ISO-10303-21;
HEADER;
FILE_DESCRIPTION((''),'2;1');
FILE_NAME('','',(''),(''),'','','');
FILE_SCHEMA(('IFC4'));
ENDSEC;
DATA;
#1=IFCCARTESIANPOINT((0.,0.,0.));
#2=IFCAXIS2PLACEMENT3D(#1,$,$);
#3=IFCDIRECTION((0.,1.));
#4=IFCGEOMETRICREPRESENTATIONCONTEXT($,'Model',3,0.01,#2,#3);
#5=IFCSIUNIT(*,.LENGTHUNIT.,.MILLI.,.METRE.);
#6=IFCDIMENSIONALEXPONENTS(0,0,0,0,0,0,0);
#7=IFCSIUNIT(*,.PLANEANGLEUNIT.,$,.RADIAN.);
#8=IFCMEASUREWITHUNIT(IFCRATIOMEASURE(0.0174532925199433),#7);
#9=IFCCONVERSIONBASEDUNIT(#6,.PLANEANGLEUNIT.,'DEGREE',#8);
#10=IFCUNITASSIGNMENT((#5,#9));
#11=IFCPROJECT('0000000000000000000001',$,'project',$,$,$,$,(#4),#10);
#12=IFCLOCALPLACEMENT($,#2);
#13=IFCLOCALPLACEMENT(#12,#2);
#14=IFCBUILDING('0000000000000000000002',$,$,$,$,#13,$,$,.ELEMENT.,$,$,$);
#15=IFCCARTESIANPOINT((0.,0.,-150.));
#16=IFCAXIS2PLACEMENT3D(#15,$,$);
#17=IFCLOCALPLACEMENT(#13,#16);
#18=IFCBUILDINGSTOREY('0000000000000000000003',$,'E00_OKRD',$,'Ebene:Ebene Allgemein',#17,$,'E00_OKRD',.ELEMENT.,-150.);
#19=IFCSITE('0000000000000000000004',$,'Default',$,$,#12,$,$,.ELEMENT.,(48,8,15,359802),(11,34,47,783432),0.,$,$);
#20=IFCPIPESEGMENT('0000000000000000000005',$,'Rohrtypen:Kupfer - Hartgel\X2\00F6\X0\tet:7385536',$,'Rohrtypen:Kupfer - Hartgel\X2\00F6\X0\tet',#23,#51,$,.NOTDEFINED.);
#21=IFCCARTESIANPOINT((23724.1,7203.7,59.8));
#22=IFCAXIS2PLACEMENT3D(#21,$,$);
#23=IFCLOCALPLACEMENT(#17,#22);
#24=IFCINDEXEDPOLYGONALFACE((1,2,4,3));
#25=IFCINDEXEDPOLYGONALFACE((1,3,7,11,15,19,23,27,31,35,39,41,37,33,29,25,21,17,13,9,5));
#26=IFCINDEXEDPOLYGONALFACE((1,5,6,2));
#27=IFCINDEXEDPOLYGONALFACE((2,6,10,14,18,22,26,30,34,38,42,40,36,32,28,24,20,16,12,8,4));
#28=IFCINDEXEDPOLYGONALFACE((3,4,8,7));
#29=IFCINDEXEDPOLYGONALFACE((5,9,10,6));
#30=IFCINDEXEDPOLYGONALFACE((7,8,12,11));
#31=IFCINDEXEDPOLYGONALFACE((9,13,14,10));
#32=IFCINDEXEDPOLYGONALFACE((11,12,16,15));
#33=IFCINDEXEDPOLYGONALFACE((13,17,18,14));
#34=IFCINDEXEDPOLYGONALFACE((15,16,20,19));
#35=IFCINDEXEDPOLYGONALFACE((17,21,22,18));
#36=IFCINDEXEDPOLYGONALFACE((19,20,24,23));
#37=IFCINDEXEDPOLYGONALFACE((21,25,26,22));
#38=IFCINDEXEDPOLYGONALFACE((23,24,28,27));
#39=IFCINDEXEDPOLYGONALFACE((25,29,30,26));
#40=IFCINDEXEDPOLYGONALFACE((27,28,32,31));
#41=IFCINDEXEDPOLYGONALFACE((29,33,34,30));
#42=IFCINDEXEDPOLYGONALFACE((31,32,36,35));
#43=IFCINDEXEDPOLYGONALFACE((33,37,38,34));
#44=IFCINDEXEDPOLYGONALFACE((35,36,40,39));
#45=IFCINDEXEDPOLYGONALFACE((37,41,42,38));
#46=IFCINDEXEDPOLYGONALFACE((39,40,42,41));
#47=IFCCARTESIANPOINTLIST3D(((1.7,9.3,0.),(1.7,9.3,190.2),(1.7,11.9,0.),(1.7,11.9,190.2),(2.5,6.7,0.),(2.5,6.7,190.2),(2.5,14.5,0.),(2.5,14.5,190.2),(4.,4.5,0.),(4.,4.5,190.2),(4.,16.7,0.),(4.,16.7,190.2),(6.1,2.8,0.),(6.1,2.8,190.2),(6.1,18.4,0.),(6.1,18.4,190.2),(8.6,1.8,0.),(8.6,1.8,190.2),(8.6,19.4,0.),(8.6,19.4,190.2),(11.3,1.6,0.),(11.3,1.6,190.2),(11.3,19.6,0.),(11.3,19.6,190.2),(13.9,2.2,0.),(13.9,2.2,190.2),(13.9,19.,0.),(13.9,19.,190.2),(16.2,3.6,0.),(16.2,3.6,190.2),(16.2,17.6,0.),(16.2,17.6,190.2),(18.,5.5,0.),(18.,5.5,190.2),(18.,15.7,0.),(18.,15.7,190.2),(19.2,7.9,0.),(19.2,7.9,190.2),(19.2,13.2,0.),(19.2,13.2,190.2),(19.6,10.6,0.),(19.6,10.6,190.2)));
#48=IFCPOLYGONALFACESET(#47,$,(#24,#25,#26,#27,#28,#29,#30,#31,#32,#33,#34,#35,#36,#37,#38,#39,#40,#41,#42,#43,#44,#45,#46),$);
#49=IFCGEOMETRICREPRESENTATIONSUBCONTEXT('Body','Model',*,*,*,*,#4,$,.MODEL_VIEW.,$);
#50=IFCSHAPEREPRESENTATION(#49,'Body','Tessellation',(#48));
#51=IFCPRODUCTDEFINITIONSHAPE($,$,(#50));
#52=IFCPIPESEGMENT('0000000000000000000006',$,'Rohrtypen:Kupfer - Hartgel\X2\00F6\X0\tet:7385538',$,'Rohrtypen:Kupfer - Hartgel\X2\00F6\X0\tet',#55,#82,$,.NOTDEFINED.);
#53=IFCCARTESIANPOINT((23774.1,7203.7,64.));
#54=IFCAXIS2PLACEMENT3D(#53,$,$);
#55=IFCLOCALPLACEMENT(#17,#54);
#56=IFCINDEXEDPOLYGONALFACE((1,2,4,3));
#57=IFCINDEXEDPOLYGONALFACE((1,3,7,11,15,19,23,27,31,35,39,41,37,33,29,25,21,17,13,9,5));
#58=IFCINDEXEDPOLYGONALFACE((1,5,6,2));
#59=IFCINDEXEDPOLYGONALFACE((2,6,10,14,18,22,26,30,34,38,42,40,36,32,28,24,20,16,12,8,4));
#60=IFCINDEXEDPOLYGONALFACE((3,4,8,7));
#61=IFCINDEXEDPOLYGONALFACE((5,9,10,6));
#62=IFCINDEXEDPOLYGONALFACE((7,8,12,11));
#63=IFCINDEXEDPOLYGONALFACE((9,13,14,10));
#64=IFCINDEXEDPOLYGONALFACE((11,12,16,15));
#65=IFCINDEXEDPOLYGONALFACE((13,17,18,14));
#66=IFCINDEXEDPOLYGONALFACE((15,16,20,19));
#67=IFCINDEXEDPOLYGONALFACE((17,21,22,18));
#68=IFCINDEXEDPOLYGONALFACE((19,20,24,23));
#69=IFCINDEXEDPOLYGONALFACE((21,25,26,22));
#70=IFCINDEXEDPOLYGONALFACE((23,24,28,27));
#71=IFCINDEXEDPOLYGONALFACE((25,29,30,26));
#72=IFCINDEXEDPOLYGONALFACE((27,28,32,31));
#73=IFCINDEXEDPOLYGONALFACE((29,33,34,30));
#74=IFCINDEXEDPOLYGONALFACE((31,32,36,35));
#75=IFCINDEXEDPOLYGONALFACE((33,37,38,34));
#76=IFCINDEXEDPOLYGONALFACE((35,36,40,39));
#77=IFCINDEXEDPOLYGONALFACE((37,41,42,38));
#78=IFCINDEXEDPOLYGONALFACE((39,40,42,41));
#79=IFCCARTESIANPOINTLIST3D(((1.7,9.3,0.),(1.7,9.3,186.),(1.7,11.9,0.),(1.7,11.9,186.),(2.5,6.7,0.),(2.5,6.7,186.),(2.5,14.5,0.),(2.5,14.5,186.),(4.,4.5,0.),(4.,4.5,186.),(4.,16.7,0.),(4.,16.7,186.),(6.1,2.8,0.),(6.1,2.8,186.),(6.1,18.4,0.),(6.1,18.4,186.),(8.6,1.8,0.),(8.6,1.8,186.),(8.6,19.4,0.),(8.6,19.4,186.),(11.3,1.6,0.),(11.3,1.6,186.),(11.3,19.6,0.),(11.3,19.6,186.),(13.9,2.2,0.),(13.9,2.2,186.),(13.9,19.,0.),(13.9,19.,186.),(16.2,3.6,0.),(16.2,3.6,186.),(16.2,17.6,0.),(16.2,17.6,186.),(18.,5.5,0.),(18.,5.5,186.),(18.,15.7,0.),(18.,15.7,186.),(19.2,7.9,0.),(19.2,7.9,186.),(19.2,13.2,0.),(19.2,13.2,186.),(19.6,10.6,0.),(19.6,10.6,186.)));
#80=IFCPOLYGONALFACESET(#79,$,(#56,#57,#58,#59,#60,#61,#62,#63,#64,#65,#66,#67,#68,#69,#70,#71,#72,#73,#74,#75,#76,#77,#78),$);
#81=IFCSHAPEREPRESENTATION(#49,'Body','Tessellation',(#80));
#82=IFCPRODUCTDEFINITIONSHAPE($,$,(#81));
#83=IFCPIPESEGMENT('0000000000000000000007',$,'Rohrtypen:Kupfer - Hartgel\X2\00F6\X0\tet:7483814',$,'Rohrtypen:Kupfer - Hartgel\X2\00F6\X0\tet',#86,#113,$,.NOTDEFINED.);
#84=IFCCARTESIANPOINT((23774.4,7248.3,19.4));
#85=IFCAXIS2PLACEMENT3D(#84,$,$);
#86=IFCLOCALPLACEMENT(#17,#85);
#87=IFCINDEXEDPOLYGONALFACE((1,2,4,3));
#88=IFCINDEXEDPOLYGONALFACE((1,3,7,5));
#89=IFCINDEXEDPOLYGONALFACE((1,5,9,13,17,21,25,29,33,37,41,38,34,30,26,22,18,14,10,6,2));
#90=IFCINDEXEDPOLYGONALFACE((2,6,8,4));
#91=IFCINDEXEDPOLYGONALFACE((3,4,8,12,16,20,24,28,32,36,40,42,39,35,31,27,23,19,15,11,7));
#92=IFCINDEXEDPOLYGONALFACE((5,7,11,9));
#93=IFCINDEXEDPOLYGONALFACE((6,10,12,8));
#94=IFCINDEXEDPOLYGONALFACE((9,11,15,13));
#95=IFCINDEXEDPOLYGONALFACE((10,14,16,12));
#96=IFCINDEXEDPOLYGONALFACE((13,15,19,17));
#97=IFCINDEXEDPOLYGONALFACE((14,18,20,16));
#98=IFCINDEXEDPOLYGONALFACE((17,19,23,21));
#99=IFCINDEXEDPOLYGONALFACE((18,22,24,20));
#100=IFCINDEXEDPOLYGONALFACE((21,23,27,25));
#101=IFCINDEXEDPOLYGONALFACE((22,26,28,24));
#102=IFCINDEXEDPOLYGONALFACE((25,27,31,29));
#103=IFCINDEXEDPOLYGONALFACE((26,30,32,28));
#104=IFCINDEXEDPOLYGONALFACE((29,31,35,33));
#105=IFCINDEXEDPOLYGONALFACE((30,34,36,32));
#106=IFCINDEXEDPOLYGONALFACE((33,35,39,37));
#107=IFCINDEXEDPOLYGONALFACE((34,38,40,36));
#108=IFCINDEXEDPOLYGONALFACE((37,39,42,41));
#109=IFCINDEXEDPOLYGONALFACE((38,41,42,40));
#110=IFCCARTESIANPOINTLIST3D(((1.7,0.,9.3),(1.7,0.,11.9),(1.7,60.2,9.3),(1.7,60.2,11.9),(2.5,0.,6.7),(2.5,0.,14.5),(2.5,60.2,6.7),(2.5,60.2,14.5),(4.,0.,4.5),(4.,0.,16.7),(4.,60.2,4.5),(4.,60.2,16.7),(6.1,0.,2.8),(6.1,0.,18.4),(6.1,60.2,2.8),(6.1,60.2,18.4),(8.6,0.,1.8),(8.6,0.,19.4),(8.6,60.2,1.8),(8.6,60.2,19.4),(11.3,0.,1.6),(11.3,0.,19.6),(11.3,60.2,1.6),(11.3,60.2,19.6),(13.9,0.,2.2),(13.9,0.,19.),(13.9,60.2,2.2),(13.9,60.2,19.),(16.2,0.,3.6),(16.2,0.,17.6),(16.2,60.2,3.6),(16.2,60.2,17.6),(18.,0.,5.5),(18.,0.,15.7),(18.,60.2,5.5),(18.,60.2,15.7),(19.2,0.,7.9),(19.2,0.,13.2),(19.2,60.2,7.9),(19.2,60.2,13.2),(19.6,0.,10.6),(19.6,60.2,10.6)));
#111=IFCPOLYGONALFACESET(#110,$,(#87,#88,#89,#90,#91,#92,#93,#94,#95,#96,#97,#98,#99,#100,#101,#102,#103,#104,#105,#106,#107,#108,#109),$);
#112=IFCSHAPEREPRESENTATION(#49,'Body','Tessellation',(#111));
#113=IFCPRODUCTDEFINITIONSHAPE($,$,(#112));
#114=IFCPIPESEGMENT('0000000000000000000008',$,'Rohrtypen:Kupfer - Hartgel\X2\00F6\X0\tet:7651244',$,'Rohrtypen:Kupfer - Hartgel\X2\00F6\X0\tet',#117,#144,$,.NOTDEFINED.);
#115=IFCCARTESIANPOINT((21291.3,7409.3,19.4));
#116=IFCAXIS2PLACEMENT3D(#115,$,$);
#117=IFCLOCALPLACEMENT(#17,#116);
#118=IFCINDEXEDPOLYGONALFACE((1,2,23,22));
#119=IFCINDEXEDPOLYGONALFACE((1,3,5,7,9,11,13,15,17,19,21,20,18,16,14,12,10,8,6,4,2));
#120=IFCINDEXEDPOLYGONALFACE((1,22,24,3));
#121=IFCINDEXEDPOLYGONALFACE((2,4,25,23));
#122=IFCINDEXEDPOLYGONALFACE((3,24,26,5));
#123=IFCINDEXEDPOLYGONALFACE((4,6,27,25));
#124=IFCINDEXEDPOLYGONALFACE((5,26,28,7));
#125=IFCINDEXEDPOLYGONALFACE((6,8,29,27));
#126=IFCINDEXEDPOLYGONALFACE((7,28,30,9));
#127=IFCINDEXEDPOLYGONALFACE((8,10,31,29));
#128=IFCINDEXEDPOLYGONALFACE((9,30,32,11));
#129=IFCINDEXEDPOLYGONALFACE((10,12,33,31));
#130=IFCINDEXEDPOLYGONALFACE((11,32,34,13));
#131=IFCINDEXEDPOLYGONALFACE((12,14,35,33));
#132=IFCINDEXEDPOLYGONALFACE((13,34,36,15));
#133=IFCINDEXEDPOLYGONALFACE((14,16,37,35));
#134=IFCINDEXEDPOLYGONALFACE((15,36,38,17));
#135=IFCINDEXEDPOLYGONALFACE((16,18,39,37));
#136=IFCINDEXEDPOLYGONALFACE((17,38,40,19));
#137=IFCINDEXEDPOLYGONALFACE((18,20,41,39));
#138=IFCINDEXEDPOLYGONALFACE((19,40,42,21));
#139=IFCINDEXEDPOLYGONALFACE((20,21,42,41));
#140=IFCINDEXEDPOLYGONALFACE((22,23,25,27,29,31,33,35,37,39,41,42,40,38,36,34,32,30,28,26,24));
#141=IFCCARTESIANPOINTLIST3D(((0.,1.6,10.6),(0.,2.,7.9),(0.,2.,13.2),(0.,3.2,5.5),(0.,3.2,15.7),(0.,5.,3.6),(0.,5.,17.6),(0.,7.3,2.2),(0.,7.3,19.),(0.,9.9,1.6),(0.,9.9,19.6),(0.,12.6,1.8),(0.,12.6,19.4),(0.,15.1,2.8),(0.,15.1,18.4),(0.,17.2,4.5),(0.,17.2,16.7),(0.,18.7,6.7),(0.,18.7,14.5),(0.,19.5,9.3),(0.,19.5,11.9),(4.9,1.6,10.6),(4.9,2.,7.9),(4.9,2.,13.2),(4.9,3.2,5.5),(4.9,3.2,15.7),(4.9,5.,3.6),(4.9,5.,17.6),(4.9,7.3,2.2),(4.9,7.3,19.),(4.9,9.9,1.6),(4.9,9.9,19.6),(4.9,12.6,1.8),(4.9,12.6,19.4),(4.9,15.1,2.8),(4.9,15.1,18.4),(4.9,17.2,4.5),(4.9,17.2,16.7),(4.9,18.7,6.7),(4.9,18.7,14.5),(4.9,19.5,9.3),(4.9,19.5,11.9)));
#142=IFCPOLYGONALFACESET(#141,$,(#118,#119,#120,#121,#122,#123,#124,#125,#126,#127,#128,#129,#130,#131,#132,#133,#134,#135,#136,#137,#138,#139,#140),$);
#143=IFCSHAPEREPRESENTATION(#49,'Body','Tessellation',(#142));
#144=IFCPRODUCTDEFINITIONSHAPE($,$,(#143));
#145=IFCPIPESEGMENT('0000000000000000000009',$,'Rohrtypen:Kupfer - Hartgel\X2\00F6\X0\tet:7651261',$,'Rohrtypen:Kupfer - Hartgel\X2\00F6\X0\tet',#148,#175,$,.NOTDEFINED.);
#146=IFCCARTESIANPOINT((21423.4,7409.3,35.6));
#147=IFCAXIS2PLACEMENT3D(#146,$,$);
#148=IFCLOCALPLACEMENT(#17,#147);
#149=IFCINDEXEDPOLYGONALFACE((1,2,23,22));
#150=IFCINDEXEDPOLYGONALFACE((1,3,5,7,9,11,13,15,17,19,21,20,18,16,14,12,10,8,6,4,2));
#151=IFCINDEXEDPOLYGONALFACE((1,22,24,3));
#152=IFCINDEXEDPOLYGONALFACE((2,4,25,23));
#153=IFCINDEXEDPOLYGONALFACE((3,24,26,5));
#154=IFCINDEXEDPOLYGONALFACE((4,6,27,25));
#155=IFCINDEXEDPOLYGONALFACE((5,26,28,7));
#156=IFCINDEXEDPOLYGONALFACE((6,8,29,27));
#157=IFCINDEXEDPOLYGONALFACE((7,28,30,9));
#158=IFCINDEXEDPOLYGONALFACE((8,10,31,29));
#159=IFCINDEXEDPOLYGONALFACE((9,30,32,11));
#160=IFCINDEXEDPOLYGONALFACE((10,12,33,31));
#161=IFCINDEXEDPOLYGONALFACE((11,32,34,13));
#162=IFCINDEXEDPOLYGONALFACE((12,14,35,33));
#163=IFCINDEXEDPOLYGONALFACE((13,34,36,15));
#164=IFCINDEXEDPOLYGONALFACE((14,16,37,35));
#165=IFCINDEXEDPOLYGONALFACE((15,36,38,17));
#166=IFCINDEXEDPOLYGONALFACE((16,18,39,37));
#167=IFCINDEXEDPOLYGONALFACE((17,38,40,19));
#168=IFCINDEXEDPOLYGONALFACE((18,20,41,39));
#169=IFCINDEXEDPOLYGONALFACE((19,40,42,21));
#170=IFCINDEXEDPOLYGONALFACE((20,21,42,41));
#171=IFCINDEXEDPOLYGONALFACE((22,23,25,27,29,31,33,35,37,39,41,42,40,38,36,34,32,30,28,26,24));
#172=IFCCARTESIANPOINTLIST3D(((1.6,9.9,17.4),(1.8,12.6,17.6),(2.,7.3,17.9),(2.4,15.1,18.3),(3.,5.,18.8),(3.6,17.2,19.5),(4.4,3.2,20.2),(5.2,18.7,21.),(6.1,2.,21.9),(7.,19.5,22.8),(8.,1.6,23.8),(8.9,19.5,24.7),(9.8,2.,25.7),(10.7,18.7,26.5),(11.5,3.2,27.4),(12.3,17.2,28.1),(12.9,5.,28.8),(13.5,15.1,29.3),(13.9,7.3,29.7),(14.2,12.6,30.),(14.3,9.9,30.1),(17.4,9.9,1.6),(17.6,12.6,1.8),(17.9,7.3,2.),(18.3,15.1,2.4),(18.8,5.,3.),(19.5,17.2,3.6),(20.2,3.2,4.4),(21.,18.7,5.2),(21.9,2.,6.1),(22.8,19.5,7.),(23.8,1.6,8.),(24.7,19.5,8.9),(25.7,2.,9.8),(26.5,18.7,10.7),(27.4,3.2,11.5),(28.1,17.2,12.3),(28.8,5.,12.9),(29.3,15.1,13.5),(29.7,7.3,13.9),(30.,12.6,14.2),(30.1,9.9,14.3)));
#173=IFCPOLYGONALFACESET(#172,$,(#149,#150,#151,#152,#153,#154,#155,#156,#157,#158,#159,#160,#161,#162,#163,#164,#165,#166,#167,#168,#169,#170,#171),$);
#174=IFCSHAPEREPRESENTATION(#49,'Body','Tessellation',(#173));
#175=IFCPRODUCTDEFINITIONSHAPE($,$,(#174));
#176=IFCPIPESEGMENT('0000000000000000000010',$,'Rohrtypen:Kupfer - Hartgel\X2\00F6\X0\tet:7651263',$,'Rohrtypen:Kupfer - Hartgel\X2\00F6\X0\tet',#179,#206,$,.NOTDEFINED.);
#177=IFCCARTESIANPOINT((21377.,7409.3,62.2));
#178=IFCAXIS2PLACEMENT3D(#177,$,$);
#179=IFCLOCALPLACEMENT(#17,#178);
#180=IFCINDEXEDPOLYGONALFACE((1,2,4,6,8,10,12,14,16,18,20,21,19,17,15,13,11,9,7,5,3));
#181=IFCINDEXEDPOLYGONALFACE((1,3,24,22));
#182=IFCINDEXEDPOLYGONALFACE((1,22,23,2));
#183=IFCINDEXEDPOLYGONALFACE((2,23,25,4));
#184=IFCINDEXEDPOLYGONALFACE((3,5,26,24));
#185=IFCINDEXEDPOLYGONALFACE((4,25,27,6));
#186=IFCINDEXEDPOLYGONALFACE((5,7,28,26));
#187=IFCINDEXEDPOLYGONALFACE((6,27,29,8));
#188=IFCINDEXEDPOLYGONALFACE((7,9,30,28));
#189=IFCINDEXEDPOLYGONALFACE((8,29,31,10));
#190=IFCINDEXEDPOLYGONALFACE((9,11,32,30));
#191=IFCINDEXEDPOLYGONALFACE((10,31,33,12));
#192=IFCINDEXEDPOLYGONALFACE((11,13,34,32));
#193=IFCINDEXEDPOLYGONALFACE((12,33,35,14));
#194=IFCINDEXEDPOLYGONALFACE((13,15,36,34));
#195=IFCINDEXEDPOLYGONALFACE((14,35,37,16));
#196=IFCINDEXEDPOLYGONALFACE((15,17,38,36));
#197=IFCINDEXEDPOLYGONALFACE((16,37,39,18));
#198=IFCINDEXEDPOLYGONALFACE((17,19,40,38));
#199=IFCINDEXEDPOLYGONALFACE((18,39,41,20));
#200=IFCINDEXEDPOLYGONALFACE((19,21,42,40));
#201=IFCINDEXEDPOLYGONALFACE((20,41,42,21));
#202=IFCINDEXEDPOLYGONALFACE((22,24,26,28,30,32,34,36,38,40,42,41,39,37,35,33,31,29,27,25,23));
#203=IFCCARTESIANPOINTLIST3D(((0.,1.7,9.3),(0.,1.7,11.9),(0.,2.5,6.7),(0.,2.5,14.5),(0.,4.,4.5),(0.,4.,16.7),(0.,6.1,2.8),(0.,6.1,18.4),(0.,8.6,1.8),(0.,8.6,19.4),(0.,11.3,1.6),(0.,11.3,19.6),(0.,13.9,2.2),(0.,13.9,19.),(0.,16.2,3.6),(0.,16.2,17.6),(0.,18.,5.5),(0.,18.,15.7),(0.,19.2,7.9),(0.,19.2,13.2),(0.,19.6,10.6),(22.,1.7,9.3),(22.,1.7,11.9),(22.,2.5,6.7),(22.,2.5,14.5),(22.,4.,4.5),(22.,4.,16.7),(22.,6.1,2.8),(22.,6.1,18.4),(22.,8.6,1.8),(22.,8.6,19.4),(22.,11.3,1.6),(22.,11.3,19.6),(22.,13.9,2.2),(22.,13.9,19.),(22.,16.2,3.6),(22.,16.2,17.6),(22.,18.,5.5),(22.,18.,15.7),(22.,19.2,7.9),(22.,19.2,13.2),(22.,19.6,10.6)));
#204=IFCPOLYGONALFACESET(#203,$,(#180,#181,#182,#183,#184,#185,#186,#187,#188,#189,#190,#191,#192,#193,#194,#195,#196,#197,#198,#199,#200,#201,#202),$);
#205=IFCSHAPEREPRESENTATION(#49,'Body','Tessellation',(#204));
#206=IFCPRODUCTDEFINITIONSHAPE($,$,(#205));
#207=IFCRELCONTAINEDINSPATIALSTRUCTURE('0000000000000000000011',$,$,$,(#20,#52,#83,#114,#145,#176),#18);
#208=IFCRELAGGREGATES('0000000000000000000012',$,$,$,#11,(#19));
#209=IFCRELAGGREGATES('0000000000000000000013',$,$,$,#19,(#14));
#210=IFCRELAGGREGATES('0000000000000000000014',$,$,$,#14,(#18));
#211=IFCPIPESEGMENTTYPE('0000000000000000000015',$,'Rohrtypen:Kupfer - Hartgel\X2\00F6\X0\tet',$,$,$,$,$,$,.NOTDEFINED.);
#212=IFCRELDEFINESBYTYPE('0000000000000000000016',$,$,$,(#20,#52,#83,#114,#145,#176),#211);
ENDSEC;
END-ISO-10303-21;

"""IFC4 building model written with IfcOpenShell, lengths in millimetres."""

from ifc_helpers import new_model, entity, si_unit, converted_unit, direction, frame, frame_2d, origin, origin_2d_with_axis, place, context, subcontext, project, spatial, circle, extrude, type_object, element, save


model = new_model("IFC4")

# Units and contexts
model_context = context("Model", 3, precision=0.01, world=origin(), true_north=direction((0.0, 1.0)))
body_context = subcontext(model_context, "Body", "Model", "MODEL_VIEW")
ifc_project = project(units=[si_unit("LENGTHUNIT", "METRE", prefix="MILLI"), converted_unit("PLANEANGLEUNIT", "DEGREE", entity("IfcRatioMeasure", 0.0174532925199433), si_unit("PLANEANGLEUNIT", "RADIAN"), dimensions=[0, 0, 0, 0, 0, 0, 0])], contexts=[model_context])

# Site, building, storey
site_placement = place(None, origin())
site = spatial("IfcSite", under=ifc_project, at=site_placement, Name="Default", CompositionType="ELEMENT", RefLatitude=(48, 8, 15, 359802), RefLongitude=(11, 34, 47, 783432), RefElevation=0.0)
building_placement = place(site_placement, origin())
building = spatial("IfcBuilding", under=site, at=building_placement, CompositionType="ELEMENT")
storey_placement = place(building_placement, frame((0.0, 0.0, -150.0)))
storey = spatial("IfcBuildingStorey", under=building, at=storey_placement, Name="E00_OKRD", ObjectType="Ebene:Ebene Allgemein", LongName="E00_OKRD", CompositionType="ELEMENT", Elevation=-150.0)

# Pipe segments
pipe_segment_type = type_object("IfcPipeSegmentType", Name="Rohrtypen:Kupfer - Hartgelötet", PredefinedType="NOTDEFINED")
pipe_segment_1_placement = place(storey_placement, frame((23724.1, 7203.7, 59.8)))
element("IfcPipeSegment", 1, at=pipe_segment_1_placement, inside=storey, type_object=pipe_segment_type, Name="Rohrtypen:Kupfer - Hartgelötet:7385536", ObjectType="Rohrtypen:Kupfer - Hartgelötet", PredefinedType="NOTDEFINED", context=body_context, shape_type="SweptSolid", body=[
    extrude(circle(Radius=9.0, at=origin_2d_with_axis()), frame((10.6, 10.6, 0.0)), (0.0, 0.0, 1.0), 190.2),
])
pipe_segment_2_placement = place(storey_placement, frame((23774.1, 7203.7, 64.0)))
element("IfcPipeSegment", 2, at=pipe_segment_2_placement, inside=storey, type_object=pipe_segment_type, Name="Rohrtypen:Kupfer - Hartgelötet:7385538", ObjectType="Rohrtypen:Kupfer - Hartgelötet", PredefinedType="NOTDEFINED", context=body_context, shape_type="SweptSolid", body=[
    extrude(circle(Radius=9.0, at=origin_2d_with_axis()), frame((10.6, 10.6, 0.0)), (0.0, 0.0, 1.0), 186.0),
])
pipe_segment_3_placement = place(storey_placement, frame((23774.4, 7248.3, 19.4)))
element("IfcPipeSegment", 3, at=pipe_segment_3_placement, inside=storey, type_object=pipe_segment_type, Name="Rohrtypen:Kupfer - Hartgelötet:7483814", ObjectType="Rohrtypen:Kupfer - Hartgelötet", PredefinedType="NOTDEFINED", context=body_context, shape_type="SweptSolid", body=[
    extrude(circle(Radius=9.0, at=frame_2d((0.0, 0.0), x_axis=(1.0, 0.0))), frame((10.6, 0.0, 10.6), z_axis=(0.0, 1.0, 0.0), x_axis=(1.0, 0.0, 0.0)), (0.0, 0.0, 1.0), 60.2),
])
pipe_segment_4_placement = place(storey_placement, frame((21291.3, 7409.3, 19.4)))
element("IfcPipeSegment", 4, at=pipe_segment_4_placement, inside=storey, type_object=pipe_segment_type, Name="Rohrtypen:Kupfer - Hartgelötet:7651244", ObjectType="Rohrtypen:Kupfer - Hartgelötet", PredefinedType="NOTDEFINED", context=body_context, shape_type="SweptSolid", body=[
    extrude(circle(Radius=9.0, at=frame_2d((0.0, 0.0), x_axis=(1.0, 0.0))), frame((0.0, 10.6, 10.6), z_axis=(1.0, 0.0, 0.0), x_axis=(0.0, -1.0, 0.0)), (0.0, 0.0, 1.0), 4.9),
])
pipe_segment_5_placement = place(storey_placement, frame((21423.4, 7409.3, 35.6)))
element("IfcPipeSegment", 5, at=pipe_segment_5_placement, inside=storey, type_object=pipe_segment_type, Name="Rohrtypen:Kupfer - Hartgelötet:7651261", ObjectType="Rohrtypen:Kupfer - Hartgelötet", PredefinedType="NOTDEFINED", context=body_context, shape_type="SweptSolid", body=[
    extrude(circle(Radius=9.0, at=origin_2d_with_axis()), frame((23.8, 10.6, 8.0), z_axis=(-0.707107, 0.0, 0.707107), x_axis=(0.0, -1.0, 0.0)), (0.0, 0.0, 1.0), 22.4),
])
pipe_segment_6_placement = place(storey_placement, frame((21377.0, 7409.3, 62.2)))
element("IfcPipeSegment", 6, at=pipe_segment_6_placement, inside=storey, type_object=pipe_segment_type, Name="Rohrtypen:Kupfer - Hartgelötet:7651263", ObjectType="Rohrtypen:Kupfer - Hartgelötet", PredefinedType="NOTDEFINED", context=body_context, shape_type="SweptSolid", body=[
    extrude(circle(Radius=9.0, at=origin_2d_with_axis()), frame((0.0, 10.6, 10.6), z_axis=(1.0, 0.0, 0.0), x_axis=(0.0, 1.0, 0.0)), (0.0, 0.0, 1.0), 22.0),
])

save(model, "model.ifc")
